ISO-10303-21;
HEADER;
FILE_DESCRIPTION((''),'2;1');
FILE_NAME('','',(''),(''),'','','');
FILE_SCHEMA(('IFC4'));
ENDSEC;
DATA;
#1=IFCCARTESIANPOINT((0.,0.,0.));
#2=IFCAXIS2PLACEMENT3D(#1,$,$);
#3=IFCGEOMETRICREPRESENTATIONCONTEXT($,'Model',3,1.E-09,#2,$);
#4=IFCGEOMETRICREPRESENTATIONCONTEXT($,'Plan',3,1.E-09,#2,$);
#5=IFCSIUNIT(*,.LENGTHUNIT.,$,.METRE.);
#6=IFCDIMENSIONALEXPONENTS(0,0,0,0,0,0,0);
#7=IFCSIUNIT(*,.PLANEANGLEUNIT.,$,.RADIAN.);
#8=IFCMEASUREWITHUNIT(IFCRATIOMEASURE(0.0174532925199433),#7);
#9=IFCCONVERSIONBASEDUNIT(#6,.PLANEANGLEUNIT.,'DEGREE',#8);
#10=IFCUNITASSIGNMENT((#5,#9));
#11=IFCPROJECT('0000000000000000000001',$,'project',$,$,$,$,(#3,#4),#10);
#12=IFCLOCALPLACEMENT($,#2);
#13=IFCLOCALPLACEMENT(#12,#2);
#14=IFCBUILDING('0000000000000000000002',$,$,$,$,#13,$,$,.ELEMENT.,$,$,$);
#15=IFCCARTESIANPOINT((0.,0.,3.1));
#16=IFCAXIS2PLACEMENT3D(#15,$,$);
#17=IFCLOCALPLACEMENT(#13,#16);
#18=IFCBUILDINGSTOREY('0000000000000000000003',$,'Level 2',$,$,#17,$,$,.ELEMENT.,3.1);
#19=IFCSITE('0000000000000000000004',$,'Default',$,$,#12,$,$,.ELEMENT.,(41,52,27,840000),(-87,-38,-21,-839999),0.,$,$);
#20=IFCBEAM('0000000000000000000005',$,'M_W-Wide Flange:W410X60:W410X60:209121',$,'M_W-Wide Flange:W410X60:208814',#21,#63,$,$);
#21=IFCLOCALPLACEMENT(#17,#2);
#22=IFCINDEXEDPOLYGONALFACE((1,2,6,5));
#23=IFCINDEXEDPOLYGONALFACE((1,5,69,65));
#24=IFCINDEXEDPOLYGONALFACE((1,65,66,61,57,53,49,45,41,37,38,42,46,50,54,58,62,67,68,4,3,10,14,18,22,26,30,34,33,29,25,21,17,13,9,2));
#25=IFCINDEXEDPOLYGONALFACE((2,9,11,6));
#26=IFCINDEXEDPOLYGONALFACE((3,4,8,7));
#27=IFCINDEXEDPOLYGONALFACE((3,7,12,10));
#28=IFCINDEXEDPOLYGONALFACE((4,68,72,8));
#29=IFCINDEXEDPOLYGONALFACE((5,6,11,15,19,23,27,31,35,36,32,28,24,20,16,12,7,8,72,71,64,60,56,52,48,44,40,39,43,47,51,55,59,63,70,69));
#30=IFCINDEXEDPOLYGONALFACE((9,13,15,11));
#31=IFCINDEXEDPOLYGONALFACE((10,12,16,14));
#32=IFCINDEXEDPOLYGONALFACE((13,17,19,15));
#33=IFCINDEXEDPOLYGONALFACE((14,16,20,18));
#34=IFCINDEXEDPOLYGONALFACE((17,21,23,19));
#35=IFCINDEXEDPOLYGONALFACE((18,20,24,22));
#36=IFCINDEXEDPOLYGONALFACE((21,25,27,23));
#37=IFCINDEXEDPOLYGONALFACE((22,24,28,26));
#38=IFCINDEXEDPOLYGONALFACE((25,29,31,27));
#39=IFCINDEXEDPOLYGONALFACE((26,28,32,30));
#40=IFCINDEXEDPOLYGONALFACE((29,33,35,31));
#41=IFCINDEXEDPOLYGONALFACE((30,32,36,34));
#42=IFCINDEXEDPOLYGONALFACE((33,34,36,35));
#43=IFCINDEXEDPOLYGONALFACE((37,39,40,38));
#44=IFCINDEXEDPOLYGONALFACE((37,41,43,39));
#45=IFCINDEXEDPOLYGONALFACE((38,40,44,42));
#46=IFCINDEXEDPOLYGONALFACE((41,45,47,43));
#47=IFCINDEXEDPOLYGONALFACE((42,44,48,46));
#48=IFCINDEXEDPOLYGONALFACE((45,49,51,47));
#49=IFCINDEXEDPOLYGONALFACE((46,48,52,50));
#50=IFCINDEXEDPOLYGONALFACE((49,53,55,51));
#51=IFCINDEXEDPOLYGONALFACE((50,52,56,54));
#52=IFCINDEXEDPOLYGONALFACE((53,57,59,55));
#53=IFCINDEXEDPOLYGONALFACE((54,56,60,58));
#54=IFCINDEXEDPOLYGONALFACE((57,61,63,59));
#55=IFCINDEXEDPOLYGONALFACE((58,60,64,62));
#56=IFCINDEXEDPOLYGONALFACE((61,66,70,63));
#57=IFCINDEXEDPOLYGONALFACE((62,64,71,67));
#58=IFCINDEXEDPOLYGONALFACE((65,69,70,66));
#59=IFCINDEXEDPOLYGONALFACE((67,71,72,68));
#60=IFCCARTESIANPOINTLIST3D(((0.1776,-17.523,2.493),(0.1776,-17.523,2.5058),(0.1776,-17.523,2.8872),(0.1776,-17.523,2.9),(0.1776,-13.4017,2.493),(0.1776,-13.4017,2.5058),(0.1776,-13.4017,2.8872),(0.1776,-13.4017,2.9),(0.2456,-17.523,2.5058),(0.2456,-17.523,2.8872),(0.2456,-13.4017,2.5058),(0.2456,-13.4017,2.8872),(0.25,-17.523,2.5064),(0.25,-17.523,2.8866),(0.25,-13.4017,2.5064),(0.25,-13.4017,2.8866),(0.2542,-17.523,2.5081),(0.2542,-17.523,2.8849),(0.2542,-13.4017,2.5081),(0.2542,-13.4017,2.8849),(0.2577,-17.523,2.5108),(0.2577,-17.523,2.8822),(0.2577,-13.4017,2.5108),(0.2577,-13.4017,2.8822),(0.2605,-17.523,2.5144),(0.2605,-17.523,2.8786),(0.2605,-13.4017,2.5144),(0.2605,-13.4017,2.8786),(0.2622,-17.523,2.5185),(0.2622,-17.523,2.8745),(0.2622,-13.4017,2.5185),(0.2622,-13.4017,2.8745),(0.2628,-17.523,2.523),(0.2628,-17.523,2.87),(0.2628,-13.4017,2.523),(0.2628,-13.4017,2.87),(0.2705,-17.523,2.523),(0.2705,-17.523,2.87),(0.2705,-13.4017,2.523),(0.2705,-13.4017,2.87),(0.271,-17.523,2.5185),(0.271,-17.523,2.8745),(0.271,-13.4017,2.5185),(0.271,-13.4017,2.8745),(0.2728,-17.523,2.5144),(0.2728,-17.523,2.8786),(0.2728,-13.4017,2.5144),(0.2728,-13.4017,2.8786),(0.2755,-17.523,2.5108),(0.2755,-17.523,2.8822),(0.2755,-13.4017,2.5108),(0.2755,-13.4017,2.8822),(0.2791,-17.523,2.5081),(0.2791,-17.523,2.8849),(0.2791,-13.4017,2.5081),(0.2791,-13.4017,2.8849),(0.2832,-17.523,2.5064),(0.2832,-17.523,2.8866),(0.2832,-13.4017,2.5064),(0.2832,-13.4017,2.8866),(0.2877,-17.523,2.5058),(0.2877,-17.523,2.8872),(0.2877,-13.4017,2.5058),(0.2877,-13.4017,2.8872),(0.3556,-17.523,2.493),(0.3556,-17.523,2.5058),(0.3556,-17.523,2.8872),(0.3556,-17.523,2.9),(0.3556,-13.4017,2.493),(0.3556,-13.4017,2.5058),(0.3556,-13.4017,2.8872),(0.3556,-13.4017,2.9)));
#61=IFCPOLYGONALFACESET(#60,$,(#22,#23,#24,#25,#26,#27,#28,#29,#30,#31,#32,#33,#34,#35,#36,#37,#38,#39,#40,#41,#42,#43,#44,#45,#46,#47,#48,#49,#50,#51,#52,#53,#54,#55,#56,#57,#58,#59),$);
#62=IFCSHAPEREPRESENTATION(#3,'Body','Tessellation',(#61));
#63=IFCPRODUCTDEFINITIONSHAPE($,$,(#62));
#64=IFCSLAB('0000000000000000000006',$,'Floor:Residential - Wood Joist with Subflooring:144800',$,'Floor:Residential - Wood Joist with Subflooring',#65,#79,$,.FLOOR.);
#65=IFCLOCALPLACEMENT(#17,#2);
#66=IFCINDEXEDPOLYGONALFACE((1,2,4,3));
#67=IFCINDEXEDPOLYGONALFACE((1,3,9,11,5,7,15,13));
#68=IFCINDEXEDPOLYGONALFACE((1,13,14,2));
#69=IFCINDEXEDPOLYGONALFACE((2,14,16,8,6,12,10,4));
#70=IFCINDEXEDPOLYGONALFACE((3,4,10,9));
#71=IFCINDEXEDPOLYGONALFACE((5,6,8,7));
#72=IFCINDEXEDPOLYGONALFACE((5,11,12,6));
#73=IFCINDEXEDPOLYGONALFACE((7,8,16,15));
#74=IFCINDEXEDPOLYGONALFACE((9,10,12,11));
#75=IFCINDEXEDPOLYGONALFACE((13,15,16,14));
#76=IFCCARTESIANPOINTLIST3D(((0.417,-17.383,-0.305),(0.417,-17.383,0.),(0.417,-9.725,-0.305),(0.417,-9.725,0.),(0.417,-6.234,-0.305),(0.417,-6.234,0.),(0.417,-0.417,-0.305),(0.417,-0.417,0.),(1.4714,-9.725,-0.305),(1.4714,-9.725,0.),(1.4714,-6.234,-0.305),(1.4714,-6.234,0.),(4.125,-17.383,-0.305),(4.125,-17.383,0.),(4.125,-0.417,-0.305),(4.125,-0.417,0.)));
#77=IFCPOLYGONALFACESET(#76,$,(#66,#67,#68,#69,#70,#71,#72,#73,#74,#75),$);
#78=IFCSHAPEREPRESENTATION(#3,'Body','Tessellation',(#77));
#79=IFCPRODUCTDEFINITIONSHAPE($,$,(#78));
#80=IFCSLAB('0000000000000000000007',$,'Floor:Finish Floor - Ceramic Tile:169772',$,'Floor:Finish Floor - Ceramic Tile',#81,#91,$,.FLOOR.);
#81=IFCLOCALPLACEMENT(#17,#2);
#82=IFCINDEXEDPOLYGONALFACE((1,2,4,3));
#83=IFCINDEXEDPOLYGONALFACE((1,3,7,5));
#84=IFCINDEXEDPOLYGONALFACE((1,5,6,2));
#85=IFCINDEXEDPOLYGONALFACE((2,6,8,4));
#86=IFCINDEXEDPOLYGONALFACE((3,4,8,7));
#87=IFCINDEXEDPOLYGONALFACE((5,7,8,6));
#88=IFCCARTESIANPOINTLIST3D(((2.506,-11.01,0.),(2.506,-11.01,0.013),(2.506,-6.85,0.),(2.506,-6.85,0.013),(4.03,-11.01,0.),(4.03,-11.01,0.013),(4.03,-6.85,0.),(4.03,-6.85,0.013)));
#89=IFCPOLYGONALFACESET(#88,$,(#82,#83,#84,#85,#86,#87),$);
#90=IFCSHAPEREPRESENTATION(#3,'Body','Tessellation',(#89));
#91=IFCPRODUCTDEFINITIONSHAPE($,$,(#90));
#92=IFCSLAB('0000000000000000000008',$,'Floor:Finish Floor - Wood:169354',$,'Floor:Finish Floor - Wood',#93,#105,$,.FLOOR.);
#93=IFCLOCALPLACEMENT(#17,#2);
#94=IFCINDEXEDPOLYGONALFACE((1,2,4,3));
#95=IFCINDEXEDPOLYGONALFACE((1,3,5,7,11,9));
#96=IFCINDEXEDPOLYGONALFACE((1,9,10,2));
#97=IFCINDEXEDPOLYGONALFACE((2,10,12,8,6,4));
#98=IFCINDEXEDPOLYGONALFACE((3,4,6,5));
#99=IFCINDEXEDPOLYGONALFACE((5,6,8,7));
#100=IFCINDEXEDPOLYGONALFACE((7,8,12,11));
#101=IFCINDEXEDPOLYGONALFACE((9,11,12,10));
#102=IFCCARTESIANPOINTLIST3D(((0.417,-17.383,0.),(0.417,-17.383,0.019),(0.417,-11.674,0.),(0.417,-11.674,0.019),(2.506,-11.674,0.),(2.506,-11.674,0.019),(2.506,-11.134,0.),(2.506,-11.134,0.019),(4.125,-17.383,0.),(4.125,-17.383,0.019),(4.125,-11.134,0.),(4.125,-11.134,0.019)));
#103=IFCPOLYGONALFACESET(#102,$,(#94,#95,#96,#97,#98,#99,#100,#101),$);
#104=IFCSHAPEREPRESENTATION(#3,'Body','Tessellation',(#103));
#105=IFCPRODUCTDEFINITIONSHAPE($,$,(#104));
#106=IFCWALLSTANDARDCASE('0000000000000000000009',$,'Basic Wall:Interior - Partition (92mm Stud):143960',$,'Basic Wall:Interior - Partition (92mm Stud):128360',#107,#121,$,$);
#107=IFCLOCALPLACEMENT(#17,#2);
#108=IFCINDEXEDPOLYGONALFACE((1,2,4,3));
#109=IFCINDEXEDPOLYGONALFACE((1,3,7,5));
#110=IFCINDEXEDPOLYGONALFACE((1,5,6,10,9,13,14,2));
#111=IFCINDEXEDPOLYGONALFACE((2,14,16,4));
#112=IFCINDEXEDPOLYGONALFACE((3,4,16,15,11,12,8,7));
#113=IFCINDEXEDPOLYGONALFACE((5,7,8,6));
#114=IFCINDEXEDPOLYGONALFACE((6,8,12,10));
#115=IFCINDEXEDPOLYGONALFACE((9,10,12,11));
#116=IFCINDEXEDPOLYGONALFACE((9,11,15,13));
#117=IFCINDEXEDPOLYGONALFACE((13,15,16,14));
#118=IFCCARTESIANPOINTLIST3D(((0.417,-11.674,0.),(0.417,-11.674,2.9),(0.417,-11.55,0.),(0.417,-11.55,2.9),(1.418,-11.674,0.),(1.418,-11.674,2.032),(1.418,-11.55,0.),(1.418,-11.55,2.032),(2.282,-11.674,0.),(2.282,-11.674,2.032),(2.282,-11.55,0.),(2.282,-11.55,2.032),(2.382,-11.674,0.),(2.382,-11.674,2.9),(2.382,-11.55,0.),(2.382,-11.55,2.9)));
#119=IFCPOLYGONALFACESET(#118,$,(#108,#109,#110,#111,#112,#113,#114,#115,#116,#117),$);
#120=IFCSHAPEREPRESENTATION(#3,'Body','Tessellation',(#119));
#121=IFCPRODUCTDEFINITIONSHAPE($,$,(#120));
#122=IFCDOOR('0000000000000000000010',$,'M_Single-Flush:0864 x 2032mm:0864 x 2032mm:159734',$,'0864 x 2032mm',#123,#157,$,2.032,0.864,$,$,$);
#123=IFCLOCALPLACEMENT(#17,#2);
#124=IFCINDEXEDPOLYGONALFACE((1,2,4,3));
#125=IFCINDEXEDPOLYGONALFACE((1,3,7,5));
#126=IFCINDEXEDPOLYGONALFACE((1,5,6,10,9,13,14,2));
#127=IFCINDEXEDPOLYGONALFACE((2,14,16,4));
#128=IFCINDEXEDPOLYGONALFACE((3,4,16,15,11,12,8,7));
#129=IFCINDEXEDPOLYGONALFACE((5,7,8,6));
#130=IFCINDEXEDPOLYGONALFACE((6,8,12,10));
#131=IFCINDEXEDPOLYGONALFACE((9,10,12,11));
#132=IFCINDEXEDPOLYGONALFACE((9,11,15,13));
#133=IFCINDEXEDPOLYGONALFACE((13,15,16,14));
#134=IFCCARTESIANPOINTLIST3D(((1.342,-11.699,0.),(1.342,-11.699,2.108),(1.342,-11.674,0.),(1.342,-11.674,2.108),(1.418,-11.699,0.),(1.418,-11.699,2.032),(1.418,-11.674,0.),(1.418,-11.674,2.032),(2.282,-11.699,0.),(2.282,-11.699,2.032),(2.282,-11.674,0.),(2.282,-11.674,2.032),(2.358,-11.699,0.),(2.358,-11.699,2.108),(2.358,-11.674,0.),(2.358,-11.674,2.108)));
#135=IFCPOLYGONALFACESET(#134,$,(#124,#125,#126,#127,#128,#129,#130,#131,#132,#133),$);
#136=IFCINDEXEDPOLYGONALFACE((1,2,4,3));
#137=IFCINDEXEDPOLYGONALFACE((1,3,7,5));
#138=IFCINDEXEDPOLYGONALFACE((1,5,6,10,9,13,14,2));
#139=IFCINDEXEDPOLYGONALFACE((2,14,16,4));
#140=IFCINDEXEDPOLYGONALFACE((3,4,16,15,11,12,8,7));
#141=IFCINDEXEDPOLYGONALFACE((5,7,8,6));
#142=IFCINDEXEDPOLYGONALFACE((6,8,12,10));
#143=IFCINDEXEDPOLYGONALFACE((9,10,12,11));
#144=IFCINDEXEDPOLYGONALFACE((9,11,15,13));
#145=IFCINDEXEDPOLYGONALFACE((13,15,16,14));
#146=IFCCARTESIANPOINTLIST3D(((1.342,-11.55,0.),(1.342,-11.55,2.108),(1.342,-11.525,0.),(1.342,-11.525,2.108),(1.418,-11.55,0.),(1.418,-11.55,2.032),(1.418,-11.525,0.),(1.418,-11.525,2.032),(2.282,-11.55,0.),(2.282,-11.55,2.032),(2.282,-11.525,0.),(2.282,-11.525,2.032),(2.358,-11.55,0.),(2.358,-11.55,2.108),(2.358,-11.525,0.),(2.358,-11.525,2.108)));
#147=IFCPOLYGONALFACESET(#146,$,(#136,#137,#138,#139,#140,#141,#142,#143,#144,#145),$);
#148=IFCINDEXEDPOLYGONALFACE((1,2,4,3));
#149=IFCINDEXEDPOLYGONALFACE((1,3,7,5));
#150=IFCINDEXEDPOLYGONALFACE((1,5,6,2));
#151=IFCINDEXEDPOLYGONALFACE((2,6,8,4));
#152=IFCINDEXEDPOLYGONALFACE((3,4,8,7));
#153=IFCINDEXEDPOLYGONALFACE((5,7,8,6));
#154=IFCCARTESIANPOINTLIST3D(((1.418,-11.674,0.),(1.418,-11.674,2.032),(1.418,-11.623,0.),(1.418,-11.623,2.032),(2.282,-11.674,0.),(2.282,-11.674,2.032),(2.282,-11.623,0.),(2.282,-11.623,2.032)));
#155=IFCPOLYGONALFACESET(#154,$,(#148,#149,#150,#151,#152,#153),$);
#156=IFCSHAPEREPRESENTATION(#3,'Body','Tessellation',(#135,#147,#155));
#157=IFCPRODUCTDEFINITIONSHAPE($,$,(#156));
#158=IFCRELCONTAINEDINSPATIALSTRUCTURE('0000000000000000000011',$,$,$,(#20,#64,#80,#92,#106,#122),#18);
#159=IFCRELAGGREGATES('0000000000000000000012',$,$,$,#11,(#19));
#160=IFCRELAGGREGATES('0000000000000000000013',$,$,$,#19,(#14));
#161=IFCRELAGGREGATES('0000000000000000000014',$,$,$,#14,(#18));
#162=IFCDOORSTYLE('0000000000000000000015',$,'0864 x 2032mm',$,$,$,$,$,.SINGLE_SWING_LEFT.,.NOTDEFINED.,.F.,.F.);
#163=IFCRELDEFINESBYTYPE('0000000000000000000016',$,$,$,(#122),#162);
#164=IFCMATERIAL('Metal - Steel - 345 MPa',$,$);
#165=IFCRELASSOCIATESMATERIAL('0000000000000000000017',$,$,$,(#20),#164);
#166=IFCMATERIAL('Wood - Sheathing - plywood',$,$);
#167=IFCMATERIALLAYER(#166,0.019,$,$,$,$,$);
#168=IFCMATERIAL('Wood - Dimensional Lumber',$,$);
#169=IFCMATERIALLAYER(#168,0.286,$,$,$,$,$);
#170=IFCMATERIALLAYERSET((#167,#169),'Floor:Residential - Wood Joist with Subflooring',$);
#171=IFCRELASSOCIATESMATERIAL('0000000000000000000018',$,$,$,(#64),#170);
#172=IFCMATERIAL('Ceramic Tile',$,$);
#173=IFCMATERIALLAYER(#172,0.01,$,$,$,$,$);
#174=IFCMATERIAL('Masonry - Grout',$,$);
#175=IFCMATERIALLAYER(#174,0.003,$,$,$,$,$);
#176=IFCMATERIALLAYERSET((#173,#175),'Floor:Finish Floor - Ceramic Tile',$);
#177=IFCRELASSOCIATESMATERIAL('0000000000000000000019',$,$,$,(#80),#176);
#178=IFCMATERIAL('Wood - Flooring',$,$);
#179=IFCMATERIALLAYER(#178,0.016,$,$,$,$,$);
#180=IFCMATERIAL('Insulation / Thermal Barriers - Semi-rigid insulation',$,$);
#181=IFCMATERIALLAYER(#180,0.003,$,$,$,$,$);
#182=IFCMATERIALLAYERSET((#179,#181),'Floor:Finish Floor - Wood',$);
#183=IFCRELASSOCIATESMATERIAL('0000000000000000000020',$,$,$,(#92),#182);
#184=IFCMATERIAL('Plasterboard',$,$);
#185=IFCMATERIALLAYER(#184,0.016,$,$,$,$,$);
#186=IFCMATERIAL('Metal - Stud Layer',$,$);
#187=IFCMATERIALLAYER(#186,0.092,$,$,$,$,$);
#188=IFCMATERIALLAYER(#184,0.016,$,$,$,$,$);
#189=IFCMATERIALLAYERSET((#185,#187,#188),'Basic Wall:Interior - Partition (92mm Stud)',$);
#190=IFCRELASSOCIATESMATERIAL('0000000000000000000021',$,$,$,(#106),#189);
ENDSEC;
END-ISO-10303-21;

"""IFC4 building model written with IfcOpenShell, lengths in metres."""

from ifc_helpers import new_model, entity, si_unit, converted_unit, frame, frame_2d, origin, origin_2d_with_axis, place, context, project, spatial, polyline, circle_curve, parameter, trimmed, segment, composite_curve, rectangle, outline, extrude, source, transform, mapped, material, layer, layer_set, layer_usage, type_object, type_shapes, element, fill, save


model = new_model("IFC4")

# Units and contexts
model_context = context("Model", 3, precision=1e-09, world=origin())
plan_context = context("Plan", 3, precision=1e-09, world=origin())
ifc_project = project(units=[si_unit("LENGTHUNIT", "METRE"), converted_unit("PLANEANGLEUNIT", "DEGREE", entity("IfcRatioMeasure", 0.0174532925199433), si_unit("PLANEANGLEUNIT", "RADIAN"), dimensions=[0, 0, 0, 0, 0, 0, 0])], contexts=[model_context, plan_context])

# Site, building, storey
site_placement = place(None, origin())
site = spatial("IfcSite", under=ifc_project, at=site_placement, Name="Default", CompositionType="ELEMENT", RefLatitude=(41, 52, 27, 840000), RefLongitude=(-87, -38, -21, -839999), RefElevation=0.0)
building_placement = place(site_placement, origin())
building = spatial("IfcBuilding", under=site, at=building_placement, CompositionType="ELEMENT")
storey_placement = place(building_placement, frame((0.0, 0.0, 3.1)))
storey = spatial("IfcBuildingStorey", under=building, at=storey_placement, Name="Level 2", CompositionType="ELEMENT", Elevation=3.1)

# Beam
ifc_material_1 = material(Name="Metal - Steel - 345 MPa")
beam_placement = place(storey_placement, frame((0.2666, -13.4017, 2.9), z_axis=(0.0, 0.0, 1.0), x_axis=(-1.0, 0.0, 0.0)))
element("IfcBeam", 1, at=beam_placement, inside=storey, material=ifc_material_1, Name="M_W-Wide Flange:W410X60:W410X60:209121", ObjectType="M_W-Wide Flange:W410X60:208814", context=model_context, shape_type="SweptSolid", body=[
    extrude(outline(composite_curve([segment(polyline([(0.1907, -0.089), (0.2035, -0.089)]), True, "CONTINUOUS"), segment(polyline([(0.2035, -0.089), (0.2035, 0.089)]), True, "CONTINUOUS"), segment(polyline([(0.2035, 0.089), (0.1907, 0.089)]), True, "CONTINUOUS"), segment(polyline([(0.1907, 0.089), (0.1907, 0.021)]), True, "CONTINUOUS"), segment(trimmed(circle_curve(frame_2d((0.1735, 0.021), x_axis=(1.0, 0.0)), 0.0172), [parameter(270.0)], [parameter(360.0)], True, "PARAMETER"), False, "CONTINUOUS"), segment(polyline([(0.1735, 0.0038), (-0.1735, 0.0038)]), True, "CONTINUOUS"), segment(trimmed(circle_curve(frame_2d((-0.1735, 0.021), x_axis=(0.0, -1.0)), 0.0172), [parameter(270.0)], [parameter(360.0)], True, "PARAMETER"), False, "CONTINUOUS"), segment(polyline([(-0.1907, 0.021), (-0.1907, 0.089)]), True, "CONTINUOUS"), segment(polyline([(-0.1907, 0.089), (-0.2035, 0.089)]), True, "CONTINUOUS"), segment(polyline([(-0.2035, 0.089), (-0.2035, -0.089)]), True, "CONTINUOUS"), segment(polyline([(-0.2035, -0.089), (-0.1907, -0.089)]), True, "CONTINUOUS"), segment(polyline([(-0.1907, -0.089), (-0.1907, -0.0211)]), True, "CONTINUOUS"), segment(trimmed(circle_curve(frame_2d((-0.1735, -0.0211), x_axis=(-1.0, 0.0)), 0.0172), [parameter(270.0)], [parameter(0.0)], True, "PARAMETER"), False, "CONTINUOUS"), segment(polyline([(-0.1735, -0.0039), (0.1735, -0.0039)]), True, "CONTINUOUS"), segment(trimmed(circle_curve(frame_2d((0.1735, -0.0211), x_axis=(0.0, 1.0)), 0.0172), [parameter(270.0)], [parameter(0.0)], True, "PARAMETER"), False, "CONTINUOUS"), segment(polyline([(0.1907, -0.0211), (0.1907, -0.089)]), True, "CONTINUOUS")], self_intersect=False)), frame((0.0, 4.1213, -0.2035), z_axis=(0.0, -1.0, 0.0), x_axis=(0.0, 0.0, -1.0)), (0.0, 0.0, 1.0), 4.1213),
])

# Slabs
ifc_material_2 = material(Name="Wood - Sheathing - plywood")
ifc_layer_1 = layer(ifc_material_2, 0.019)
ifc_material_3 = material(Name="Wood - Dimensional Lumber")
ifc_layer_2 = layer(ifc_material_3, 0.286)
ifc_layer_set_1 = layer_set([ifc_layer_1, ifc_layer_2], Name="Floor:Residential - Wood Joist with Subflooring")
ifc_layer_usage_1 = layer_usage(ifc_layer_set_1, "AXIS3", "POSITIVE", 0.0)
slab_1_placement = place(storey_placement, frame((0.417, -17.383, -0.305)))
element("IfcSlab", 2, at=slab_1_placement, inside=storey, material=ifc_layer_usage_1, Name="Floor:Residential - Wood Joist with Subflooring:144800", ObjectType="Floor:Residential - Wood Joist with Subflooring", PredefinedType="FLOOR", context=model_context, shape_type="SweptSolid", body=[
    extrude(outline(polyline([(-1.854, 8.483), (-1.854, -8.483), (1.854, -8.483), (1.854, -0.825), (0.7996, -0.825), (0.7996, 2.666), (1.854, 2.666), (1.854, 8.483), (-1.854, 8.483)])), frame((1.854, 8.483, 0.305), z_axis=(0.0, 0.0, -1.0), x_axis=(-1.0, 0.0, 0.0)), (0.0, 0.0, 1.0), 0.305),
])
ifc_material_4 = material(Name="Ceramic Tile")
ifc_layer_3 = layer(ifc_material_4, 0.01)
ifc_material_5 = material(Name="Masonry - Grout")
ifc_layer_4 = layer(ifc_material_5, 0.003)
ifc_layer_set_2 = layer_set([ifc_layer_3, ifc_layer_4], Name="Floor:Finish Floor - Ceramic Tile")
ifc_layer_usage_2 = layer_usage(ifc_layer_set_2, "AXIS3", "POSITIVE", 0.0)
slab_2_placement = place(storey_placement, frame((2.506, -11.01, 0.0)))
element("IfcSlab", 3, at=slab_2_placement, inside=storey, material=ifc_layer_usage_2, Name="Floor:Finish Floor - Ceramic Tile:169772", ObjectType="Floor:Finish Floor - Ceramic Tile", PredefinedType="FLOOR", context=model_context, shape_type="SweptSolid", body=[
    extrude(rectangle(XDim=4.16, YDim=1.524, at=frame_2d((0.0, 0.0), x_axis=(0.0, -1.0))), frame((0.762, 2.08, 0.013), z_axis=(0.0, 0.0, -1.0), x_axis=(-1.0, 0.0, 0.0)), (0.0, 0.0, 1.0), 0.013),
])
ifc_material_6 = material(Name="Wood - Flooring")
ifc_layer_5 = layer(ifc_material_6, 0.016)
ifc_material_7 = material(Name="Insulation / Thermal Barriers - Semi-rigid insulation")
ifc_layer_6 = layer(ifc_material_7, 0.003)
ifc_layer_set_3 = layer_set([ifc_layer_5, ifc_layer_6], Name="Floor:Finish Floor - Wood")
ifc_layer_usage_3 = layer_usage(ifc_layer_set_3, "AXIS3", "POSITIVE", 0.0)
slab_3_placement = place(storey_placement, frame((0.417, -17.383, 0.0)))
element("IfcSlab", 4, at=slab_3_placement, inside=storey, material=ifc_layer_usage_3, Name="Floor:Finish Floor - Wood:169354", ObjectType="Floor:Finish Floor - Wood", PredefinedType="FLOOR", context=model_context, shape_type="SweptSolid", body=[
    extrude(outline(polyline([(-1.854, -3.1245), (1.854, -3.1245), (1.854, 2.5845), (-0.235, 2.5845), (-0.235, 3.1245), (-1.854, 3.1245), (-1.854, -3.1245)])), frame((1.854, 3.1245, 0.019), z_axis=(0.0, 0.0, -1.0), x_axis=(-1.0, 0.0, 0.0)), (0.0, 0.0, 1.0), 0.019),
])

# Shared definitions
ifc_material_8 = material(Name="Metal - Stud Layer")
ifc_material_9 = material(Name="Plasterboard")

# Wall, opening, door
ifc_layer_7 = layer(ifc_material_9, 0.016)
ifc_layer_8 = layer(ifc_material_8, 0.092)
ifc_layer_9 = layer(ifc_material_9, 0.016)
ifc_layer_set_4 = layer_set([ifc_layer_7, ifc_layer_8, ifc_layer_9], Name="Basic Wall:Interior - Partition (92mm Stud)")
ifc_layer_usage_4 = layer_usage(ifc_layer_set_4, "AXIS2", "NEGATIVE", 0.062)
wall_1_placement = place(storey_placement, frame((2.382, -11.612, 0.0), z_axis=(0.0, 0.0, 1.0), x_axis=(-1.0, 0.0, 0.0)))
wall_1 = element("IfcWallStandardCase", 5, at=wall_1_placement, inside=storey, material=ifc_layer_usage_4, Name="Basic Wall:Interior - Partition (92mm Stud):143960", ObjectType="Basic Wall:Interior - Partition (92mm Stud):128360", context=model_context, shape_type="SweptSolid", body=[
    extrude(rectangle(XDim=1.965, YDim=0.124, at=frame_2d((0.9825, 0.0), x_axis=(-1.0, 0.0))), origin(), (0.0, 0.0, 1.0), 2.9),
])
opening_1_placement = place(wall_1_placement, frame((0.1, -0.062, 0.0)))
opening_1 = element("IfcOpeningElement", 6, at=opening_1_placement, cuts=wall_1, ObjectType="Opening", context=model_context, shape_type="SweptSolid", body=[
    extrude(rectangle(XDim=0.864, YDim=2.032, at=frame_2d((1.016, 0.432), x_axis=(0.0, -1.0))), frame((0.0, 0.0, 0.0), z_axis=(0.0, 1.0, 0.0), x_axis=(0.0, 0.0, 1.0)), (0.0, 0.0, 1.0), 0.124),
])
door_style = type_object("IfcDoorStyle", Name="0864 x 2032mm", ConstructionType="NOTDEFINED", OperationType="SINGLE_SWING_LEFT", ParameterTakesPrecedence=False, Sizeable=False)
shared_shape_1 = source(origin(), model_context, "Body", "SweptSolid", [
    extrude(outline(polyline([(-0.508, -1.073), (0.508, -1.073), (0.508, 1.035), (0.432, 1.035), (0.432, -0.997), (-0.432, -0.997), (-0.432, 1.035), (-0.508, 1.035), (-0.508, -1.073)])), frame((0.432, 0.149, 1.035), z_axis=(0.0, -1.0, 0.0), x_axis=(-1.0, 0.0, 0.0)), (0.0, 0.0, 1.0), 0.025),
    extrude(outline(polyline([(-1.073, -0.508), (1.035, -0.508), (1.035, -0.432), (-0.997, -0.432), (-0.997, 0.432), (1.035, 0.432), (1.035, 0.508), (-1.073, 0.508), (-1.073, -0.508)])), frame((0.432, 0.0, 1.035), z_axis=(0.0, -1.0, 0.0), x_axis=(0.0, 0.0, -1.0)), (0.0, 0.0, 1.0), 0.025),
    extrude(rectangle(XDim=0.864, YDim=0.051, at=origin_2d_with_axis()), frame((0.432, 0.0985, 0.0)), (0.0, 0.0, 1.0), 2.032),
])
type_shapes(door_style, [shared_shape_1])
door_placement = place(opening_1_placement, origin())
door = element("IfcDoor", 7, at=door_placement, inside=storey, type_object=door_style, Name="M_Single-Flush:0864 x 2032mm:0864 x 2032mm:159734", ObjectType="0864 x 2032mm", OverallHeight=2.032, OverallWidth=0.864, context=model_context, shape_type="MappedRepresentation", body=[
    mapped(shared_shape_1, transform((0.0, 0.0, 0.0), scale=1.0)),
])
fill(opening_1, door)

save(model, "model.ifc")
